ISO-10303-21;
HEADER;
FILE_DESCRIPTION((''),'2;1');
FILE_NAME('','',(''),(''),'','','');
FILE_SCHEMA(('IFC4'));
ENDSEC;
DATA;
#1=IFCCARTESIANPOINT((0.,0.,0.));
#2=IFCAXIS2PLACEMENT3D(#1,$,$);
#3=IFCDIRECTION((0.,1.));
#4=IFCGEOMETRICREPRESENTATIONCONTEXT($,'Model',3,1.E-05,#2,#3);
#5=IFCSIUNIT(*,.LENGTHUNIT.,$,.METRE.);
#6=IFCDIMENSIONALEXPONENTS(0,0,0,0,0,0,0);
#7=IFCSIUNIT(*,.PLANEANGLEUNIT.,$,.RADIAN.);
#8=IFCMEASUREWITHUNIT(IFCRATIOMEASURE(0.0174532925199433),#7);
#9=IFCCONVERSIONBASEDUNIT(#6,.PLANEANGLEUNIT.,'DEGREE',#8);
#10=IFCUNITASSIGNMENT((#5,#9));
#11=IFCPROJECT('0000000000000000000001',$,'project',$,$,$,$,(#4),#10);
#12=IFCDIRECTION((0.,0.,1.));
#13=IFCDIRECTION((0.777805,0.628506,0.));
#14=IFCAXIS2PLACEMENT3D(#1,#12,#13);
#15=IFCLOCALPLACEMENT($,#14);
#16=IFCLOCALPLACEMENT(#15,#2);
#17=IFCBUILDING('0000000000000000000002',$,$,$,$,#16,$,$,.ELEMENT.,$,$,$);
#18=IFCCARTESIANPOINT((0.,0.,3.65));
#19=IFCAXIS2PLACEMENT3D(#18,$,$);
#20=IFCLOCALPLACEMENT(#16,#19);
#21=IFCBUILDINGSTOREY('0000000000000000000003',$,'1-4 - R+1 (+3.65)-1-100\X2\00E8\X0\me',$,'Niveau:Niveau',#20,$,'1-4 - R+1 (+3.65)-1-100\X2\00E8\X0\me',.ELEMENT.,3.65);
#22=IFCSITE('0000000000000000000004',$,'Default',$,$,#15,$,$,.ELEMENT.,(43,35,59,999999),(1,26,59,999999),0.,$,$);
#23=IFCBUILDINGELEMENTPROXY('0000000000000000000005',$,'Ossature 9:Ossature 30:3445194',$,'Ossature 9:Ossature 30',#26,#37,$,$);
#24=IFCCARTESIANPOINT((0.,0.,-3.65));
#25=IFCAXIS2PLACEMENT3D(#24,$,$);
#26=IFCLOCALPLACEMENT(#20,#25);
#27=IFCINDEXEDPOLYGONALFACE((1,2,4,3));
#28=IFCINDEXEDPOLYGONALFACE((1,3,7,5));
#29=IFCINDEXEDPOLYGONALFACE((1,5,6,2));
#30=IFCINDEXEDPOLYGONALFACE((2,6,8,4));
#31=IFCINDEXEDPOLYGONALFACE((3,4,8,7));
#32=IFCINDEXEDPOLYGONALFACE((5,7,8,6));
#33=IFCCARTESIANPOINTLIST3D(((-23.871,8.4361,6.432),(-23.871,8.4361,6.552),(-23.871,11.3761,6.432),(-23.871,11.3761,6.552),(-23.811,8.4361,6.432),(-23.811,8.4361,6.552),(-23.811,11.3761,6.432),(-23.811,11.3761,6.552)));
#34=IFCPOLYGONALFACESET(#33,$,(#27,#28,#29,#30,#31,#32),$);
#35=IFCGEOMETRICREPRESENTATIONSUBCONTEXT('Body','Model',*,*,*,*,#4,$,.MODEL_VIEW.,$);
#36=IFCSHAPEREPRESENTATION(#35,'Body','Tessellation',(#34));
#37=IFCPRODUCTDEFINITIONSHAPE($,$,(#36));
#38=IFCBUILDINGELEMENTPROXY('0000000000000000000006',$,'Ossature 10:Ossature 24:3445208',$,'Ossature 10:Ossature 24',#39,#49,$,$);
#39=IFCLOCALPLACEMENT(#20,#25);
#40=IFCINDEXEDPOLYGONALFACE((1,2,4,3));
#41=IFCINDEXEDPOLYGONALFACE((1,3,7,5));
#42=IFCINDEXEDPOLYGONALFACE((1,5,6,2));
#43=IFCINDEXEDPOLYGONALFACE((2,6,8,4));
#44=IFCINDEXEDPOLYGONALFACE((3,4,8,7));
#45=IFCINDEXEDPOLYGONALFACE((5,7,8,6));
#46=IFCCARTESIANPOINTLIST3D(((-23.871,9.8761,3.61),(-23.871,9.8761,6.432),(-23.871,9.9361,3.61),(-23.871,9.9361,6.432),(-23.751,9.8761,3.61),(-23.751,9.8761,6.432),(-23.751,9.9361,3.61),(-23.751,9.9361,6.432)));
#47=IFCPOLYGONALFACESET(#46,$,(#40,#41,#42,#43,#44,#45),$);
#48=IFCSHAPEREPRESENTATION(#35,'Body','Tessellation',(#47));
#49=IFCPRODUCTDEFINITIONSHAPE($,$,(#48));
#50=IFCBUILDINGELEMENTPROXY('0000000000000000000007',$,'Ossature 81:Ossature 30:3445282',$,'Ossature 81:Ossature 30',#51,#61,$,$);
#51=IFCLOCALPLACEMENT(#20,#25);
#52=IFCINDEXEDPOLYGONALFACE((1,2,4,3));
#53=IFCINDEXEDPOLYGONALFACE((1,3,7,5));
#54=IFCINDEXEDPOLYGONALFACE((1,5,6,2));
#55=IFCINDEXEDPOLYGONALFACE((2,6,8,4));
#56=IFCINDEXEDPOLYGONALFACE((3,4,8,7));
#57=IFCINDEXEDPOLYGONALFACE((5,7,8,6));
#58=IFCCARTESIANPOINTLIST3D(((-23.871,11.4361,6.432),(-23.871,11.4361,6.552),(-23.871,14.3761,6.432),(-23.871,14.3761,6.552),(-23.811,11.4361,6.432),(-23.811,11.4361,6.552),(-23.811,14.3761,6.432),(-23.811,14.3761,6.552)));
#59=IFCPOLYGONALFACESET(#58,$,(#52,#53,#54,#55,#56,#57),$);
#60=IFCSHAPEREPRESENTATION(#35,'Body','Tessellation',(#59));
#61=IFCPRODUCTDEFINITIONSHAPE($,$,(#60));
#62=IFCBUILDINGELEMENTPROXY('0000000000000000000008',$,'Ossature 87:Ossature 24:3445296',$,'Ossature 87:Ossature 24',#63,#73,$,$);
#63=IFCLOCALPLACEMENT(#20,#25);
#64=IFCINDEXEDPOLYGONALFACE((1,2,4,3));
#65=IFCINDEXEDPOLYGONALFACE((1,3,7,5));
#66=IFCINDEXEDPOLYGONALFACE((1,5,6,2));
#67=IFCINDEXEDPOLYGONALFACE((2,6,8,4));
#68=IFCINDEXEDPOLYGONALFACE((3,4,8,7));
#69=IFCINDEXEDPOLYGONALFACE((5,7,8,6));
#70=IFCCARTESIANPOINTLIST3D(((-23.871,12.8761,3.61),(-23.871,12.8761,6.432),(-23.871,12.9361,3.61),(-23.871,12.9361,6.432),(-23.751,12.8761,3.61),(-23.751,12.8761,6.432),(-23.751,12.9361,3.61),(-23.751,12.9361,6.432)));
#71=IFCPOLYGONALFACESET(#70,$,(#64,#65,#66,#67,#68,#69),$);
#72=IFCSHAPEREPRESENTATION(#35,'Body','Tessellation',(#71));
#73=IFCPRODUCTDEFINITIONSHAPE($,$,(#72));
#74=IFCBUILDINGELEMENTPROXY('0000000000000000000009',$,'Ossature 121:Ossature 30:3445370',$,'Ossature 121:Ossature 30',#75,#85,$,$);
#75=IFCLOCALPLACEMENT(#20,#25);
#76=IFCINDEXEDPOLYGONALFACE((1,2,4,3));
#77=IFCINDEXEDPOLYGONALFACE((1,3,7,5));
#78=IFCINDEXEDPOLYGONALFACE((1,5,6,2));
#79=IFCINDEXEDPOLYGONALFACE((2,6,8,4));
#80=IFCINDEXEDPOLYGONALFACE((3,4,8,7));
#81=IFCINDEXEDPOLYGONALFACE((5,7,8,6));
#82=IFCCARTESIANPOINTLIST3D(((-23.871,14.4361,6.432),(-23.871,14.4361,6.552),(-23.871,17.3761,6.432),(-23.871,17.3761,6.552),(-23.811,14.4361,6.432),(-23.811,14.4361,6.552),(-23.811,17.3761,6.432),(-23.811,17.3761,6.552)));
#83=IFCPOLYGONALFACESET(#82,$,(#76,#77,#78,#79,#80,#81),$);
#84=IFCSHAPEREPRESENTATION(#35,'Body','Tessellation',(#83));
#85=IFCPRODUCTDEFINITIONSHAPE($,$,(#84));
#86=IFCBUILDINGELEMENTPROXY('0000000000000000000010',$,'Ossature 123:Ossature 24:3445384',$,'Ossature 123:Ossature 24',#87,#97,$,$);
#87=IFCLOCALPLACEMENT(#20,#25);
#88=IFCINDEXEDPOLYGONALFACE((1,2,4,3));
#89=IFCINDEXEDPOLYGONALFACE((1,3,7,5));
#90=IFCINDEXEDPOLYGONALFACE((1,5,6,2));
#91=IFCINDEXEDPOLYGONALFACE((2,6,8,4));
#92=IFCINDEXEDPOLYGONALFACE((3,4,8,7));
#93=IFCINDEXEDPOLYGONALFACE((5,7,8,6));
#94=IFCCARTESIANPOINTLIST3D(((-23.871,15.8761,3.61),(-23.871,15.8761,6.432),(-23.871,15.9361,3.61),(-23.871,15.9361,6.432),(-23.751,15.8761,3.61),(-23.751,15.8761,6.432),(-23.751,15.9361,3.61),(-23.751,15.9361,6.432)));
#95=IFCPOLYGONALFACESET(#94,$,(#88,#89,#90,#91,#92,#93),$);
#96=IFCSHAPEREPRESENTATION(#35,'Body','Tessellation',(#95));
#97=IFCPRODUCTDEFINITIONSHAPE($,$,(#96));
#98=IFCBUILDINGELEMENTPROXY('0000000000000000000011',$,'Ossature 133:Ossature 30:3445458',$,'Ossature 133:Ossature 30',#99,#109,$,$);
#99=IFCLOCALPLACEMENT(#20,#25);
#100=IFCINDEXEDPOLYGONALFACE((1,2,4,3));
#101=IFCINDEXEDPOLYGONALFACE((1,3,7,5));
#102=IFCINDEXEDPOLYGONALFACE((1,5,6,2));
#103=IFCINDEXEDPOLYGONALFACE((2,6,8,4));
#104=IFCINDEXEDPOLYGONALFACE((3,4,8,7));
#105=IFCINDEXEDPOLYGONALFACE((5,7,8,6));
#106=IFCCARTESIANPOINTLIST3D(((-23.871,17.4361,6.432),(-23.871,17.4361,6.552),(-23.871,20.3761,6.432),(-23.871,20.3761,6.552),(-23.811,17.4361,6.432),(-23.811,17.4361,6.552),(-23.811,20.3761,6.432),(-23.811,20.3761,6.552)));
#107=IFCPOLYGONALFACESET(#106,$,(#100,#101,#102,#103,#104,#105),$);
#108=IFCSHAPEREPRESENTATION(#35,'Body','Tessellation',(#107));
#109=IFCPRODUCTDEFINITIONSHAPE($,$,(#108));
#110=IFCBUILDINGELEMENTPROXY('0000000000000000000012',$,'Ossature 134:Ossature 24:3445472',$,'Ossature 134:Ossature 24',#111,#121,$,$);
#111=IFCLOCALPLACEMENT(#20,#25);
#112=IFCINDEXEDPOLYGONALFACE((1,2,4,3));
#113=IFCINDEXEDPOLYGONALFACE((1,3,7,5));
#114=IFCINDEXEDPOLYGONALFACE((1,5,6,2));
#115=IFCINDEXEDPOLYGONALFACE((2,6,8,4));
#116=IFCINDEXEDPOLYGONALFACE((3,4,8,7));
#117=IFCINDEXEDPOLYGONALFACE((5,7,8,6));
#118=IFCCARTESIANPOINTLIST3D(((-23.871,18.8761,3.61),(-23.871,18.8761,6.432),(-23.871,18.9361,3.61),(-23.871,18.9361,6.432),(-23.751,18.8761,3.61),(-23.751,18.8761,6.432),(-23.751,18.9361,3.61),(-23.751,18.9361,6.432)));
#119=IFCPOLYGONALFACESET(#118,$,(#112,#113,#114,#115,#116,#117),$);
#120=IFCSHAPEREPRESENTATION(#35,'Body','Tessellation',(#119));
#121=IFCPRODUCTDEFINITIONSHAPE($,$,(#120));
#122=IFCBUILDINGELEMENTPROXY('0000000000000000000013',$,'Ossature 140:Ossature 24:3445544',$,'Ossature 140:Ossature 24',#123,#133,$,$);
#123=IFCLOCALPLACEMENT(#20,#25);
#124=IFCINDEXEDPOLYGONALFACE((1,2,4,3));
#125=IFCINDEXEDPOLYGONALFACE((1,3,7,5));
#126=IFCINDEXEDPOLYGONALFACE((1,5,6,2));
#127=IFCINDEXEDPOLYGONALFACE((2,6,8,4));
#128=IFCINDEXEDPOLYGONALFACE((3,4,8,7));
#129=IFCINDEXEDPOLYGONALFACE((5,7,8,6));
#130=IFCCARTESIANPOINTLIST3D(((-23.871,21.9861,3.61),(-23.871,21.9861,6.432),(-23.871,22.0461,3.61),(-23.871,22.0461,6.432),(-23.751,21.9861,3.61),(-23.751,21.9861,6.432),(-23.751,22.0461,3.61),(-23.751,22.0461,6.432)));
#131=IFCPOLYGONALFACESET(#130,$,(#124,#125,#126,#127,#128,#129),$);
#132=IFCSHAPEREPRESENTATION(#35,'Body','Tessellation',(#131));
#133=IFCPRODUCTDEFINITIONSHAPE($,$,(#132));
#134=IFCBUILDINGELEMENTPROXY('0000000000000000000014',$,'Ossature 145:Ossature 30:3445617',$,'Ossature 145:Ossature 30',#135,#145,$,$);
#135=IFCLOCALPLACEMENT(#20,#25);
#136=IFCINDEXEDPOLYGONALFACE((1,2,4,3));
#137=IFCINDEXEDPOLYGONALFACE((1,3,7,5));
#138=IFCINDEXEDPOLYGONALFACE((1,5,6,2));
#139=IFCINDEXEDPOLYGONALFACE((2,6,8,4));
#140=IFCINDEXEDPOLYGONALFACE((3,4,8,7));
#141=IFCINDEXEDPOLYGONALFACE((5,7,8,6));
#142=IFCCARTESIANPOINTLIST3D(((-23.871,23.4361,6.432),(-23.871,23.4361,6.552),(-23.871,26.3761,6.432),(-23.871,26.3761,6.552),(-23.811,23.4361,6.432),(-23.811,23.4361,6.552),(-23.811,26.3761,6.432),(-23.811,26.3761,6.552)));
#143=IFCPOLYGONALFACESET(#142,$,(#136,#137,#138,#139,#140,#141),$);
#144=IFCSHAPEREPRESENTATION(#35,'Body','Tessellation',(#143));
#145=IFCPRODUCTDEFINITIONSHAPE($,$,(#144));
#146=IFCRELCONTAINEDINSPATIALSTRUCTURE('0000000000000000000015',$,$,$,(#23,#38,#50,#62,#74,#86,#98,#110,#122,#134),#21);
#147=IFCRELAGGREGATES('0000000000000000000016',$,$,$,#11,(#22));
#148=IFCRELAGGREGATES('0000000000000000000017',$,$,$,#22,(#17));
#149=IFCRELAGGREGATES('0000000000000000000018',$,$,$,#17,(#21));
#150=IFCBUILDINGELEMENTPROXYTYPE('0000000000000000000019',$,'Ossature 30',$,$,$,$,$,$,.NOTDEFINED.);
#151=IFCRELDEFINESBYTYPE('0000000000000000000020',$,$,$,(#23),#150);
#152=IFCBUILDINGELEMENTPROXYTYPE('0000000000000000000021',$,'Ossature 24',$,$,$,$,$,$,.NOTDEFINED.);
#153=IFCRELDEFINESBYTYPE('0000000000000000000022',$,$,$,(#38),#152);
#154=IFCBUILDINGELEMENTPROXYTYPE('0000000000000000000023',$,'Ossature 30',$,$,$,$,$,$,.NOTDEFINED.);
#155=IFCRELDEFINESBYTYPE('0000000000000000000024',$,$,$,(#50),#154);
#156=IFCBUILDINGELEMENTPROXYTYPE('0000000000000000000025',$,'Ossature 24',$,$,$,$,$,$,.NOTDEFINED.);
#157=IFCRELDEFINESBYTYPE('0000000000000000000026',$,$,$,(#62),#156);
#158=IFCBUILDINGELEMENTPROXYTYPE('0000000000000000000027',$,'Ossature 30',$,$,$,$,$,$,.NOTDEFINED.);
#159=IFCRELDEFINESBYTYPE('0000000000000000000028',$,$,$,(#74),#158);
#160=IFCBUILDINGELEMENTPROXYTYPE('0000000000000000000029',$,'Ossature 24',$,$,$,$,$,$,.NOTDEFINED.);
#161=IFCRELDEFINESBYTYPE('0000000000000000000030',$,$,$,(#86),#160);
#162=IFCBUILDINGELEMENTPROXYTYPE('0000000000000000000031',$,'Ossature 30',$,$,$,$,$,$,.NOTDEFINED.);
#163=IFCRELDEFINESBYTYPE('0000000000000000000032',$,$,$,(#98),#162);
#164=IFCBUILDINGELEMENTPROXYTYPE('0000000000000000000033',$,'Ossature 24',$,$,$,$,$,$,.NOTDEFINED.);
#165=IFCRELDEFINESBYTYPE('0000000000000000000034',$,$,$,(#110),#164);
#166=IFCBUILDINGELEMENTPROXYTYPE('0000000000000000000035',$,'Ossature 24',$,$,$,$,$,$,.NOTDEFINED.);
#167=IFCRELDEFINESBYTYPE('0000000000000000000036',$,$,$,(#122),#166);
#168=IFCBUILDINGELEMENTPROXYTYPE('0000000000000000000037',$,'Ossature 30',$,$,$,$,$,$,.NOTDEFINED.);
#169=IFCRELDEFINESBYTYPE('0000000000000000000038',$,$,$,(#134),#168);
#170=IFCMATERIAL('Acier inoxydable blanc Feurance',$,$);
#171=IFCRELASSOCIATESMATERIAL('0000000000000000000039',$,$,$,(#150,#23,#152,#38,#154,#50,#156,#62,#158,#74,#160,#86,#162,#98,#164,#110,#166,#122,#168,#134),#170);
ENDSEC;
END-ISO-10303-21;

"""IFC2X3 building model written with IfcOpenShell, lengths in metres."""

from ifc_helpers import new_model, entity, si_unit, converted_unit, direction, frame, frame_2d, origin, origin_2d_with_axis, place, context, subcontext, project, spatial, rectangle, extrude, source, transform, mapped, material, type_object, type_shapes, element, save


model = new_model("IFC2X3")

# Units and contexts
model_context = context("Model", 3, precision=1e-05, world=origin(), true_north=direction((0.0, 1.0)))
body_context = subcontext(model_context, "Body", "Model", "MODEL_VIEW")
ifc_project = project(units=[si_unit("LENGTHUNIT", "METRE"), converted_unit("PLANEANGLEUNIT", "DEGREE", entity("IfcRatioMeasure", 0.0174532925199433), si_unit("PLANEANGLEUNIT", "RADIAN"), dimensions=[0, 0, 0, 0, 0, 0, 0])], contexts=[model_context])

# Site, building, storey
site_placement = place(None, frame((0.0, 0.0, 0.0), z_axis=(0.0, 0.0, 1.0), x_axis=(0.777805, 0.628506, 0.0)))
site = spatial("IfcSite", under=ifc_project, at=site_placement, Name="Default", CompositionType="ELEMENT", RefLatitude=(43, 35, 59, 999999), RefLongitude=(1, 26, 59, 999999), RefElevation=0.0)
building_placement = place(site_placement, origin())
building = spatial("IfcBuilding", under=site, at=building_placement, CompositionType="ELEMENT")
storey_placement = place(building_placement, frame((0.0, 0.0, 3.65)))
storey = spatial("IfcBuildingStorey", under=building, at=storey_placement, Name="1-4 - R+1 (+3.65)-1-100ème", ObjectType="Niveau:Niveau", LongName="1-4 - R+1 (+3.65)-1-100ème", CompositionType="ELEMENT", Elevation=3.65)

# Building element proxies
ifc_material_1 = material(Name="Acier inoxydable blanc Feurance")
building_element_proxy_type_1 = type_object("IfcBuildingElementProxyType", Name="Ossature 30", PredefinedType="NOTDEFINED", material=ifc_material_1)
shared_shape_1 = source(origin(), body_context, "Body", "SweptSolid", [
    extrude(rectangle(XDim=2.94, YDim=0.06, at=frame_2d((0.0, 0.0), x_axis=(1.0, 0.0))), frame((-23.841, 9.9061, 6.432), z_axis=(0.0, 0.0, 1.0), x_axis=(0.0, -1.0, 0.0)), (0.0, 0.0, 1.0), 0.12),
])
type_shapes(building_element_proxy_type_1, [shared_shape_1])
proxy_1_placement = place(storey_placement, frame((0.0, 0.0, -3.65)))
element("IfcBuildingElementProxy", 1, at=proxy_1_placement, inside=storey, type_object=building_element_proxy_type_1, material=ifc_material_1, Name="Ossature 9:Ossature 30:3445194", ObjectType="Ossature 9:Ossature 30", context=body_context, shape_type="MappedRepresentation", body=[
    mapped(shared_shape_1, transform((0.0, 0.0, 0.0), scale=1.0)),
])
building_element_proxy_type_2 = type_object("IfcBuildingElementProxyType", Name="Ossature 24", PredefinedType="NOTDEFINED", material=ifc_material_1)
shared_shape_2 = source(origin(), body_context, "Body", "SweptSolid", [
    extrude(rectangle(XDim=0.06, YDim=0.12, at=origin_2d_with_axis()), frame((-23.811, 9.9061, 3.61), z_axis=(0.0, 0.0, 1.0), x_axis=(0.0, -1.0, 0.0)), (0.0, 0.0, 1.0), 2.822),
])
type_shapes(building_element_proxy_type_2, [shared_shape_2])
proxy_2_placement = place(storey_placement, frame((0.0, 0.0, -3.65)))
element("IfcBuildingElementProxy", 2, at=proxy_2_placement, inside=storey, type_object=building_element_proxy_type_2, material=ifc_material_1, Name="Ossature 10:Ossature 24:3445208", ObjectType="Ossature 10:Ossature 24", context=body_context, shape_type="MappedRepresentation", body=[
    mapped(shared_shape_2, transform((0.0, 0.0, 0.0), scale=1.0)),
])
building_element_proxy_type_3 = type_object("IfcBuildingElementProxyType", Name="Ossature 30", PredefinedType="NOTDEFINED", material=ifc_material_1)
shared_shape_3 = source(origin(), body_context, "Body", "SweptSolid", [
    extrude(rectangle(XDim=2.94, YDim=0.06, at=frame_2d((0.0, 0.0), x_axis=(1.0, 0.0))), frame((-23.841, 12.9061, 6.432), z_axis=(0.0, 0.0, 1.0), x_axis=(0.0, -1.0, 0.0)), (0.0, 0.0, 1.0), 0.12),
])
type_shapes(building_element_proxy_type_3, [shared_shape_3])
proxy_3_placement = place(storey_placement, frame((0.0, 0.0, -3.65)))
element("IfcBuildingElementProxy", 3, at=proxy_3_placement, inside=storey, type_object=building_element_proxy_type_3, material=ifc_material_1, Name="Ossature 81:Ossature 30:3445282", ObjectType="Ossature 81:Ossature 30", context=body_context, shape_type="MappedRepresentation", body=[
    mapped(shared_shape_3, transform((0.0, 0.0, 0.0), scale=1.0)),
])
building_element_proxy_type_4 = type_object("IfcBuildingElementProxyType", Name="Ossature 24", PredefinedType="NOTDEFINED", material=ifc_material_1)
shared_shape_4 = source(origin(), body_context, "Body", "SweptSolid", [
    extrude(rectangle(XDim=0.06, YDim=0.12, at=frame_2d((0.0, 0.0), x_axis=(1.0, 0.0))), frame((-23.811, 12.9061, 3.61), z_axis=(0.0, 0.0, 1.0), x_axis=(0.0, -1.0, 0.0)), (0.0, 0.0, 1.0), 2.822),
])
type_shapes(building_element_proxy_type_4, [shared_shape_4])
proxy_4_placement = place(storey_placement, frame((0.0, 0.0, -3.65)))
element("IfcBuildingElementProxy", 4, at=proxy_4_placement, inside=storey, type_object=building_element_proxy_type_4, material=ifc_material_1, Name="Ossature 87:Ossature 24:3445296", ObjectType="Ossature 87:Ossature 24", context=body_context, shape_type="MappedRepresentation", body=[
    mapped(shared_shape_4, transform((0.0, 0.0, 0.0), scale=1.0)),
])
building_element_proxy_type_5 = type_object("IfcBuildingElementProxyType", Name="Ossature 30", PredefinedType="NOTDEFINED", material=ifc_material_1)
shared_shape_5 = source(origin(), body_context, "Body", "SweptSolid", [
    extrude(rectangle(XDim=2.94, YDim=0.06, at=frame_2d((0.0, 0.0), x_axis=(1.0, 0.0))), frame((-23.841, 15.9061, 6.432), z_axis=(0.0, 0.0, 1.0), x_axis=(0.0, -1.0, 0.0)), (0.0, 0.0, 1.0), 0.12),
])
type_shapes(building_element_proxy_type_5, [shared_shape_5])
proxy_5_placement = place(storey_placement, frame((0.0, 0.0, -3.65)))
element("IfcBuildingElementProxy", 5, at=proxy_5_placement, inside=storey, type_object=building_element_proxy_type_5, material=ifc_material_1, Name="Ossature 121:Ossature 30:3445370", ObjectType="Ossature 121:Ossature 30", context=body_context, shape_type="MappedRepresentation", body=[
    mapped(shared_shape_5, transform((0.0, 0.0, 0.0), scale=1.0)),
])
building_element_proxy_type_6 = type_object("IfcBuildingElementProxyType", Name="Ossature 24", PredefinedType="NOTDEFINED", material=ifc_material_1)
shared_shape_6 = source(origin(), body_context, "Body", "SweptSolid", [
    extrude(rectangle(XDim=0.06, YDim=0.12, at=origin_2d_with_axis()), frame((-23.811, 15.9061, 3.61), z_axis=(0.0, 0.0, 1.0), x_axis=(0.0, -1.0, 0.0)), (0.0, 0.0, 1.0), 2.822),
])
type_shapes(building_element_proxy_type_6, [shared_shape_6])
proxy_6_placement = place(storey_placement, frame((0.0, 0.0, -3.65)))
element("IfcBuildingElementProxy", 6, at=proxy_6_placement, inside=storey, type_object=building_element_proxy_type_6, material=ifc_material_1, Name="Ossature 123:Ossature 24:3445384", ObjectType="Ossature 123:Ossature 24", context=body_context, shape_type="MappedRepresentation", body=[
    mapped(shared_shape_6, transform((0.0, 0.0, 0.0), scale=1.0)),
])
building_element_proxy_type_7 = type_object("IfcBuildingElementProxyType", Name="Ossature 30", PredefinedType="NOTDEFINED", material=ifc_material_1)
shared_shape_7 = source(origin(), body_context, "Body", "SweptSolid", [
    extrude(rectangle(XDim=2.94, YDim=0.06, at=frame_2d((0.0, 0.0), x_axis=(1.0, 0.0))), frame((-23.841, 18.9061, 6.432), z_axis=(0.0, 0.0, 1.0), x_axis=(0.0, -1.0, 0.0)), (0.0, 0.0, 1.0), 0.12),
])
type_shapes(building_element_proxy_type_7, [shared_shape_7])
proxy_7_placement = place(storey_placement, frame((0.0, 0.0, -3.65)))
element("IfcBuildingElementProxy", 7, at=proxy_7_placement, inside=storey, type_object=building_element_proxy_type_7, material=ifc_material_1, Name="Ossature 133:Ossature 30:3445458", ObjectType="Ossature 133:Ossature 30", context=body_context, shape_type="MappedRepresentation", body=[
    mapped(shared_shape_7, transform((0.0, 0.0, 0.0), scale=1.0)),
])
building_element_proxy_type_8 = type_object("IfcBuildingElementProxyType", Name="Ossature 24", PredefinedType="NOTDEFINED", material=ifc_material_1)
shared_shape_8 = source(origin(), body_context, "Body", "SweptSolid", [
    extrude(rectangle(XDim=0.06, YDim=0.12, at=frame_2d((0.0, 0.0), x_axis=(1.0, 0.0))), frame((-23.811, 18.9061, 3.61), z_axis=(0.0, 0.0, 1.0), x_axis=(0.0, -1.0, 0.0)), (0.0, 0.0, 1.0), 2.822),
])
type_shapes(building_element_proxy_type_8, [shared_shape_8])
proxy_8_placement = place(storey_placement, frame((0.0, 0.0, -3.65)))
element("IfcBuildingElementProxy", 8, at=proxy_8_placement, inside=storey, type_object=building_element_proxy_type_8, material=ifc_material_1, Name="Ossature 134:Ossature 24:3445472", ObjectType="Ossature 134:Ossature 24", context=body_context, shape_type="MappedRepresentation", body=[
    mapped(shared_shape_8, transform((0.0, 0.0, 0.0), scale=1.0)),
])
building_element_proxy_type_9 = type_object("IfcBuildingElementProxyType", Name="Ossature 24", PredefinedType="NOTDEFINED", material=ifc_material_1)
shared_shape_9 = source(origin(), body_context, "Body", "SweptSolid", [
    extrude(rectangle(XDim=0.06, YDim=0.12, at=frame_2d((0.0, 0.0), x_axis=(1.0, 0.0))), frame((-23.811, 22.0161, 3.61), z_axis=(0.0, 0.0, 1.0), x_axis=(0.0, -1.0, 0.0)), (0.0, 0.0, 1.0), 2.822),
])
type_shapes(building_element_proxy_type_9, [shared_shape_9])
proxy_9_placement = place(storey_placement, frame((0.0, 0.0, -3.65)))
element("IfcBuildingElementProxy", 9, at=proxy_9_placement, inside=storey, type_object=building_element_proxy_type_9, material=ifc_material_1, Name="Ossature 140:Ossature 24:3445544", ObjectType="Ossature 140:Ossature 24", context=body_context, shape_type="MappedRepresentation", body=[
    mapped(shared_shape_9, transform((0.0, 0.0, 0.0), scale=1.0)),
])
building_element_proxy_type_10 = type_object("IfcBuildingElementProxyType", Name="Ossature 30", PredefinedType="NOTDEFINED", material=ifc_material_1)
shared_shape_10 = source(origin(), body_context, "Body", "SweptSolid", [
    extrude(rectangle(XDim=2.94, YDim=0.06, at=origin_2d_with_axis()), frame((-23.841, 24.9061, 6.432), z_axis=(0.0, 0.0, 1.0), x_axis=(0.0, -1.0, 0.0)), (0.0, 0.0, 1.0), 0.12),
])
type_shapes(building_element_proxy_type_10, [shared_shape_10])
proxy_10_placement = place(storey_placement, frame((0.0, 0.0, -3.65)))
element("IfcBuildingElementProxy", 10, at=proxy_10_placement, inside=storey, type_object=building_element_proxy_type_10, material=ifc_material_1, Name="Ossature 145:Ossature 30:3445617", ObjectType="Ossature 145:Ossature 30", context=body_context, shape_type="MappedRepresentation", body=[
    mapped(shared_shape_10, transform((0.0, 0.0, 0.0), scale=1.0)),
])

save(model, "model.ifc")
